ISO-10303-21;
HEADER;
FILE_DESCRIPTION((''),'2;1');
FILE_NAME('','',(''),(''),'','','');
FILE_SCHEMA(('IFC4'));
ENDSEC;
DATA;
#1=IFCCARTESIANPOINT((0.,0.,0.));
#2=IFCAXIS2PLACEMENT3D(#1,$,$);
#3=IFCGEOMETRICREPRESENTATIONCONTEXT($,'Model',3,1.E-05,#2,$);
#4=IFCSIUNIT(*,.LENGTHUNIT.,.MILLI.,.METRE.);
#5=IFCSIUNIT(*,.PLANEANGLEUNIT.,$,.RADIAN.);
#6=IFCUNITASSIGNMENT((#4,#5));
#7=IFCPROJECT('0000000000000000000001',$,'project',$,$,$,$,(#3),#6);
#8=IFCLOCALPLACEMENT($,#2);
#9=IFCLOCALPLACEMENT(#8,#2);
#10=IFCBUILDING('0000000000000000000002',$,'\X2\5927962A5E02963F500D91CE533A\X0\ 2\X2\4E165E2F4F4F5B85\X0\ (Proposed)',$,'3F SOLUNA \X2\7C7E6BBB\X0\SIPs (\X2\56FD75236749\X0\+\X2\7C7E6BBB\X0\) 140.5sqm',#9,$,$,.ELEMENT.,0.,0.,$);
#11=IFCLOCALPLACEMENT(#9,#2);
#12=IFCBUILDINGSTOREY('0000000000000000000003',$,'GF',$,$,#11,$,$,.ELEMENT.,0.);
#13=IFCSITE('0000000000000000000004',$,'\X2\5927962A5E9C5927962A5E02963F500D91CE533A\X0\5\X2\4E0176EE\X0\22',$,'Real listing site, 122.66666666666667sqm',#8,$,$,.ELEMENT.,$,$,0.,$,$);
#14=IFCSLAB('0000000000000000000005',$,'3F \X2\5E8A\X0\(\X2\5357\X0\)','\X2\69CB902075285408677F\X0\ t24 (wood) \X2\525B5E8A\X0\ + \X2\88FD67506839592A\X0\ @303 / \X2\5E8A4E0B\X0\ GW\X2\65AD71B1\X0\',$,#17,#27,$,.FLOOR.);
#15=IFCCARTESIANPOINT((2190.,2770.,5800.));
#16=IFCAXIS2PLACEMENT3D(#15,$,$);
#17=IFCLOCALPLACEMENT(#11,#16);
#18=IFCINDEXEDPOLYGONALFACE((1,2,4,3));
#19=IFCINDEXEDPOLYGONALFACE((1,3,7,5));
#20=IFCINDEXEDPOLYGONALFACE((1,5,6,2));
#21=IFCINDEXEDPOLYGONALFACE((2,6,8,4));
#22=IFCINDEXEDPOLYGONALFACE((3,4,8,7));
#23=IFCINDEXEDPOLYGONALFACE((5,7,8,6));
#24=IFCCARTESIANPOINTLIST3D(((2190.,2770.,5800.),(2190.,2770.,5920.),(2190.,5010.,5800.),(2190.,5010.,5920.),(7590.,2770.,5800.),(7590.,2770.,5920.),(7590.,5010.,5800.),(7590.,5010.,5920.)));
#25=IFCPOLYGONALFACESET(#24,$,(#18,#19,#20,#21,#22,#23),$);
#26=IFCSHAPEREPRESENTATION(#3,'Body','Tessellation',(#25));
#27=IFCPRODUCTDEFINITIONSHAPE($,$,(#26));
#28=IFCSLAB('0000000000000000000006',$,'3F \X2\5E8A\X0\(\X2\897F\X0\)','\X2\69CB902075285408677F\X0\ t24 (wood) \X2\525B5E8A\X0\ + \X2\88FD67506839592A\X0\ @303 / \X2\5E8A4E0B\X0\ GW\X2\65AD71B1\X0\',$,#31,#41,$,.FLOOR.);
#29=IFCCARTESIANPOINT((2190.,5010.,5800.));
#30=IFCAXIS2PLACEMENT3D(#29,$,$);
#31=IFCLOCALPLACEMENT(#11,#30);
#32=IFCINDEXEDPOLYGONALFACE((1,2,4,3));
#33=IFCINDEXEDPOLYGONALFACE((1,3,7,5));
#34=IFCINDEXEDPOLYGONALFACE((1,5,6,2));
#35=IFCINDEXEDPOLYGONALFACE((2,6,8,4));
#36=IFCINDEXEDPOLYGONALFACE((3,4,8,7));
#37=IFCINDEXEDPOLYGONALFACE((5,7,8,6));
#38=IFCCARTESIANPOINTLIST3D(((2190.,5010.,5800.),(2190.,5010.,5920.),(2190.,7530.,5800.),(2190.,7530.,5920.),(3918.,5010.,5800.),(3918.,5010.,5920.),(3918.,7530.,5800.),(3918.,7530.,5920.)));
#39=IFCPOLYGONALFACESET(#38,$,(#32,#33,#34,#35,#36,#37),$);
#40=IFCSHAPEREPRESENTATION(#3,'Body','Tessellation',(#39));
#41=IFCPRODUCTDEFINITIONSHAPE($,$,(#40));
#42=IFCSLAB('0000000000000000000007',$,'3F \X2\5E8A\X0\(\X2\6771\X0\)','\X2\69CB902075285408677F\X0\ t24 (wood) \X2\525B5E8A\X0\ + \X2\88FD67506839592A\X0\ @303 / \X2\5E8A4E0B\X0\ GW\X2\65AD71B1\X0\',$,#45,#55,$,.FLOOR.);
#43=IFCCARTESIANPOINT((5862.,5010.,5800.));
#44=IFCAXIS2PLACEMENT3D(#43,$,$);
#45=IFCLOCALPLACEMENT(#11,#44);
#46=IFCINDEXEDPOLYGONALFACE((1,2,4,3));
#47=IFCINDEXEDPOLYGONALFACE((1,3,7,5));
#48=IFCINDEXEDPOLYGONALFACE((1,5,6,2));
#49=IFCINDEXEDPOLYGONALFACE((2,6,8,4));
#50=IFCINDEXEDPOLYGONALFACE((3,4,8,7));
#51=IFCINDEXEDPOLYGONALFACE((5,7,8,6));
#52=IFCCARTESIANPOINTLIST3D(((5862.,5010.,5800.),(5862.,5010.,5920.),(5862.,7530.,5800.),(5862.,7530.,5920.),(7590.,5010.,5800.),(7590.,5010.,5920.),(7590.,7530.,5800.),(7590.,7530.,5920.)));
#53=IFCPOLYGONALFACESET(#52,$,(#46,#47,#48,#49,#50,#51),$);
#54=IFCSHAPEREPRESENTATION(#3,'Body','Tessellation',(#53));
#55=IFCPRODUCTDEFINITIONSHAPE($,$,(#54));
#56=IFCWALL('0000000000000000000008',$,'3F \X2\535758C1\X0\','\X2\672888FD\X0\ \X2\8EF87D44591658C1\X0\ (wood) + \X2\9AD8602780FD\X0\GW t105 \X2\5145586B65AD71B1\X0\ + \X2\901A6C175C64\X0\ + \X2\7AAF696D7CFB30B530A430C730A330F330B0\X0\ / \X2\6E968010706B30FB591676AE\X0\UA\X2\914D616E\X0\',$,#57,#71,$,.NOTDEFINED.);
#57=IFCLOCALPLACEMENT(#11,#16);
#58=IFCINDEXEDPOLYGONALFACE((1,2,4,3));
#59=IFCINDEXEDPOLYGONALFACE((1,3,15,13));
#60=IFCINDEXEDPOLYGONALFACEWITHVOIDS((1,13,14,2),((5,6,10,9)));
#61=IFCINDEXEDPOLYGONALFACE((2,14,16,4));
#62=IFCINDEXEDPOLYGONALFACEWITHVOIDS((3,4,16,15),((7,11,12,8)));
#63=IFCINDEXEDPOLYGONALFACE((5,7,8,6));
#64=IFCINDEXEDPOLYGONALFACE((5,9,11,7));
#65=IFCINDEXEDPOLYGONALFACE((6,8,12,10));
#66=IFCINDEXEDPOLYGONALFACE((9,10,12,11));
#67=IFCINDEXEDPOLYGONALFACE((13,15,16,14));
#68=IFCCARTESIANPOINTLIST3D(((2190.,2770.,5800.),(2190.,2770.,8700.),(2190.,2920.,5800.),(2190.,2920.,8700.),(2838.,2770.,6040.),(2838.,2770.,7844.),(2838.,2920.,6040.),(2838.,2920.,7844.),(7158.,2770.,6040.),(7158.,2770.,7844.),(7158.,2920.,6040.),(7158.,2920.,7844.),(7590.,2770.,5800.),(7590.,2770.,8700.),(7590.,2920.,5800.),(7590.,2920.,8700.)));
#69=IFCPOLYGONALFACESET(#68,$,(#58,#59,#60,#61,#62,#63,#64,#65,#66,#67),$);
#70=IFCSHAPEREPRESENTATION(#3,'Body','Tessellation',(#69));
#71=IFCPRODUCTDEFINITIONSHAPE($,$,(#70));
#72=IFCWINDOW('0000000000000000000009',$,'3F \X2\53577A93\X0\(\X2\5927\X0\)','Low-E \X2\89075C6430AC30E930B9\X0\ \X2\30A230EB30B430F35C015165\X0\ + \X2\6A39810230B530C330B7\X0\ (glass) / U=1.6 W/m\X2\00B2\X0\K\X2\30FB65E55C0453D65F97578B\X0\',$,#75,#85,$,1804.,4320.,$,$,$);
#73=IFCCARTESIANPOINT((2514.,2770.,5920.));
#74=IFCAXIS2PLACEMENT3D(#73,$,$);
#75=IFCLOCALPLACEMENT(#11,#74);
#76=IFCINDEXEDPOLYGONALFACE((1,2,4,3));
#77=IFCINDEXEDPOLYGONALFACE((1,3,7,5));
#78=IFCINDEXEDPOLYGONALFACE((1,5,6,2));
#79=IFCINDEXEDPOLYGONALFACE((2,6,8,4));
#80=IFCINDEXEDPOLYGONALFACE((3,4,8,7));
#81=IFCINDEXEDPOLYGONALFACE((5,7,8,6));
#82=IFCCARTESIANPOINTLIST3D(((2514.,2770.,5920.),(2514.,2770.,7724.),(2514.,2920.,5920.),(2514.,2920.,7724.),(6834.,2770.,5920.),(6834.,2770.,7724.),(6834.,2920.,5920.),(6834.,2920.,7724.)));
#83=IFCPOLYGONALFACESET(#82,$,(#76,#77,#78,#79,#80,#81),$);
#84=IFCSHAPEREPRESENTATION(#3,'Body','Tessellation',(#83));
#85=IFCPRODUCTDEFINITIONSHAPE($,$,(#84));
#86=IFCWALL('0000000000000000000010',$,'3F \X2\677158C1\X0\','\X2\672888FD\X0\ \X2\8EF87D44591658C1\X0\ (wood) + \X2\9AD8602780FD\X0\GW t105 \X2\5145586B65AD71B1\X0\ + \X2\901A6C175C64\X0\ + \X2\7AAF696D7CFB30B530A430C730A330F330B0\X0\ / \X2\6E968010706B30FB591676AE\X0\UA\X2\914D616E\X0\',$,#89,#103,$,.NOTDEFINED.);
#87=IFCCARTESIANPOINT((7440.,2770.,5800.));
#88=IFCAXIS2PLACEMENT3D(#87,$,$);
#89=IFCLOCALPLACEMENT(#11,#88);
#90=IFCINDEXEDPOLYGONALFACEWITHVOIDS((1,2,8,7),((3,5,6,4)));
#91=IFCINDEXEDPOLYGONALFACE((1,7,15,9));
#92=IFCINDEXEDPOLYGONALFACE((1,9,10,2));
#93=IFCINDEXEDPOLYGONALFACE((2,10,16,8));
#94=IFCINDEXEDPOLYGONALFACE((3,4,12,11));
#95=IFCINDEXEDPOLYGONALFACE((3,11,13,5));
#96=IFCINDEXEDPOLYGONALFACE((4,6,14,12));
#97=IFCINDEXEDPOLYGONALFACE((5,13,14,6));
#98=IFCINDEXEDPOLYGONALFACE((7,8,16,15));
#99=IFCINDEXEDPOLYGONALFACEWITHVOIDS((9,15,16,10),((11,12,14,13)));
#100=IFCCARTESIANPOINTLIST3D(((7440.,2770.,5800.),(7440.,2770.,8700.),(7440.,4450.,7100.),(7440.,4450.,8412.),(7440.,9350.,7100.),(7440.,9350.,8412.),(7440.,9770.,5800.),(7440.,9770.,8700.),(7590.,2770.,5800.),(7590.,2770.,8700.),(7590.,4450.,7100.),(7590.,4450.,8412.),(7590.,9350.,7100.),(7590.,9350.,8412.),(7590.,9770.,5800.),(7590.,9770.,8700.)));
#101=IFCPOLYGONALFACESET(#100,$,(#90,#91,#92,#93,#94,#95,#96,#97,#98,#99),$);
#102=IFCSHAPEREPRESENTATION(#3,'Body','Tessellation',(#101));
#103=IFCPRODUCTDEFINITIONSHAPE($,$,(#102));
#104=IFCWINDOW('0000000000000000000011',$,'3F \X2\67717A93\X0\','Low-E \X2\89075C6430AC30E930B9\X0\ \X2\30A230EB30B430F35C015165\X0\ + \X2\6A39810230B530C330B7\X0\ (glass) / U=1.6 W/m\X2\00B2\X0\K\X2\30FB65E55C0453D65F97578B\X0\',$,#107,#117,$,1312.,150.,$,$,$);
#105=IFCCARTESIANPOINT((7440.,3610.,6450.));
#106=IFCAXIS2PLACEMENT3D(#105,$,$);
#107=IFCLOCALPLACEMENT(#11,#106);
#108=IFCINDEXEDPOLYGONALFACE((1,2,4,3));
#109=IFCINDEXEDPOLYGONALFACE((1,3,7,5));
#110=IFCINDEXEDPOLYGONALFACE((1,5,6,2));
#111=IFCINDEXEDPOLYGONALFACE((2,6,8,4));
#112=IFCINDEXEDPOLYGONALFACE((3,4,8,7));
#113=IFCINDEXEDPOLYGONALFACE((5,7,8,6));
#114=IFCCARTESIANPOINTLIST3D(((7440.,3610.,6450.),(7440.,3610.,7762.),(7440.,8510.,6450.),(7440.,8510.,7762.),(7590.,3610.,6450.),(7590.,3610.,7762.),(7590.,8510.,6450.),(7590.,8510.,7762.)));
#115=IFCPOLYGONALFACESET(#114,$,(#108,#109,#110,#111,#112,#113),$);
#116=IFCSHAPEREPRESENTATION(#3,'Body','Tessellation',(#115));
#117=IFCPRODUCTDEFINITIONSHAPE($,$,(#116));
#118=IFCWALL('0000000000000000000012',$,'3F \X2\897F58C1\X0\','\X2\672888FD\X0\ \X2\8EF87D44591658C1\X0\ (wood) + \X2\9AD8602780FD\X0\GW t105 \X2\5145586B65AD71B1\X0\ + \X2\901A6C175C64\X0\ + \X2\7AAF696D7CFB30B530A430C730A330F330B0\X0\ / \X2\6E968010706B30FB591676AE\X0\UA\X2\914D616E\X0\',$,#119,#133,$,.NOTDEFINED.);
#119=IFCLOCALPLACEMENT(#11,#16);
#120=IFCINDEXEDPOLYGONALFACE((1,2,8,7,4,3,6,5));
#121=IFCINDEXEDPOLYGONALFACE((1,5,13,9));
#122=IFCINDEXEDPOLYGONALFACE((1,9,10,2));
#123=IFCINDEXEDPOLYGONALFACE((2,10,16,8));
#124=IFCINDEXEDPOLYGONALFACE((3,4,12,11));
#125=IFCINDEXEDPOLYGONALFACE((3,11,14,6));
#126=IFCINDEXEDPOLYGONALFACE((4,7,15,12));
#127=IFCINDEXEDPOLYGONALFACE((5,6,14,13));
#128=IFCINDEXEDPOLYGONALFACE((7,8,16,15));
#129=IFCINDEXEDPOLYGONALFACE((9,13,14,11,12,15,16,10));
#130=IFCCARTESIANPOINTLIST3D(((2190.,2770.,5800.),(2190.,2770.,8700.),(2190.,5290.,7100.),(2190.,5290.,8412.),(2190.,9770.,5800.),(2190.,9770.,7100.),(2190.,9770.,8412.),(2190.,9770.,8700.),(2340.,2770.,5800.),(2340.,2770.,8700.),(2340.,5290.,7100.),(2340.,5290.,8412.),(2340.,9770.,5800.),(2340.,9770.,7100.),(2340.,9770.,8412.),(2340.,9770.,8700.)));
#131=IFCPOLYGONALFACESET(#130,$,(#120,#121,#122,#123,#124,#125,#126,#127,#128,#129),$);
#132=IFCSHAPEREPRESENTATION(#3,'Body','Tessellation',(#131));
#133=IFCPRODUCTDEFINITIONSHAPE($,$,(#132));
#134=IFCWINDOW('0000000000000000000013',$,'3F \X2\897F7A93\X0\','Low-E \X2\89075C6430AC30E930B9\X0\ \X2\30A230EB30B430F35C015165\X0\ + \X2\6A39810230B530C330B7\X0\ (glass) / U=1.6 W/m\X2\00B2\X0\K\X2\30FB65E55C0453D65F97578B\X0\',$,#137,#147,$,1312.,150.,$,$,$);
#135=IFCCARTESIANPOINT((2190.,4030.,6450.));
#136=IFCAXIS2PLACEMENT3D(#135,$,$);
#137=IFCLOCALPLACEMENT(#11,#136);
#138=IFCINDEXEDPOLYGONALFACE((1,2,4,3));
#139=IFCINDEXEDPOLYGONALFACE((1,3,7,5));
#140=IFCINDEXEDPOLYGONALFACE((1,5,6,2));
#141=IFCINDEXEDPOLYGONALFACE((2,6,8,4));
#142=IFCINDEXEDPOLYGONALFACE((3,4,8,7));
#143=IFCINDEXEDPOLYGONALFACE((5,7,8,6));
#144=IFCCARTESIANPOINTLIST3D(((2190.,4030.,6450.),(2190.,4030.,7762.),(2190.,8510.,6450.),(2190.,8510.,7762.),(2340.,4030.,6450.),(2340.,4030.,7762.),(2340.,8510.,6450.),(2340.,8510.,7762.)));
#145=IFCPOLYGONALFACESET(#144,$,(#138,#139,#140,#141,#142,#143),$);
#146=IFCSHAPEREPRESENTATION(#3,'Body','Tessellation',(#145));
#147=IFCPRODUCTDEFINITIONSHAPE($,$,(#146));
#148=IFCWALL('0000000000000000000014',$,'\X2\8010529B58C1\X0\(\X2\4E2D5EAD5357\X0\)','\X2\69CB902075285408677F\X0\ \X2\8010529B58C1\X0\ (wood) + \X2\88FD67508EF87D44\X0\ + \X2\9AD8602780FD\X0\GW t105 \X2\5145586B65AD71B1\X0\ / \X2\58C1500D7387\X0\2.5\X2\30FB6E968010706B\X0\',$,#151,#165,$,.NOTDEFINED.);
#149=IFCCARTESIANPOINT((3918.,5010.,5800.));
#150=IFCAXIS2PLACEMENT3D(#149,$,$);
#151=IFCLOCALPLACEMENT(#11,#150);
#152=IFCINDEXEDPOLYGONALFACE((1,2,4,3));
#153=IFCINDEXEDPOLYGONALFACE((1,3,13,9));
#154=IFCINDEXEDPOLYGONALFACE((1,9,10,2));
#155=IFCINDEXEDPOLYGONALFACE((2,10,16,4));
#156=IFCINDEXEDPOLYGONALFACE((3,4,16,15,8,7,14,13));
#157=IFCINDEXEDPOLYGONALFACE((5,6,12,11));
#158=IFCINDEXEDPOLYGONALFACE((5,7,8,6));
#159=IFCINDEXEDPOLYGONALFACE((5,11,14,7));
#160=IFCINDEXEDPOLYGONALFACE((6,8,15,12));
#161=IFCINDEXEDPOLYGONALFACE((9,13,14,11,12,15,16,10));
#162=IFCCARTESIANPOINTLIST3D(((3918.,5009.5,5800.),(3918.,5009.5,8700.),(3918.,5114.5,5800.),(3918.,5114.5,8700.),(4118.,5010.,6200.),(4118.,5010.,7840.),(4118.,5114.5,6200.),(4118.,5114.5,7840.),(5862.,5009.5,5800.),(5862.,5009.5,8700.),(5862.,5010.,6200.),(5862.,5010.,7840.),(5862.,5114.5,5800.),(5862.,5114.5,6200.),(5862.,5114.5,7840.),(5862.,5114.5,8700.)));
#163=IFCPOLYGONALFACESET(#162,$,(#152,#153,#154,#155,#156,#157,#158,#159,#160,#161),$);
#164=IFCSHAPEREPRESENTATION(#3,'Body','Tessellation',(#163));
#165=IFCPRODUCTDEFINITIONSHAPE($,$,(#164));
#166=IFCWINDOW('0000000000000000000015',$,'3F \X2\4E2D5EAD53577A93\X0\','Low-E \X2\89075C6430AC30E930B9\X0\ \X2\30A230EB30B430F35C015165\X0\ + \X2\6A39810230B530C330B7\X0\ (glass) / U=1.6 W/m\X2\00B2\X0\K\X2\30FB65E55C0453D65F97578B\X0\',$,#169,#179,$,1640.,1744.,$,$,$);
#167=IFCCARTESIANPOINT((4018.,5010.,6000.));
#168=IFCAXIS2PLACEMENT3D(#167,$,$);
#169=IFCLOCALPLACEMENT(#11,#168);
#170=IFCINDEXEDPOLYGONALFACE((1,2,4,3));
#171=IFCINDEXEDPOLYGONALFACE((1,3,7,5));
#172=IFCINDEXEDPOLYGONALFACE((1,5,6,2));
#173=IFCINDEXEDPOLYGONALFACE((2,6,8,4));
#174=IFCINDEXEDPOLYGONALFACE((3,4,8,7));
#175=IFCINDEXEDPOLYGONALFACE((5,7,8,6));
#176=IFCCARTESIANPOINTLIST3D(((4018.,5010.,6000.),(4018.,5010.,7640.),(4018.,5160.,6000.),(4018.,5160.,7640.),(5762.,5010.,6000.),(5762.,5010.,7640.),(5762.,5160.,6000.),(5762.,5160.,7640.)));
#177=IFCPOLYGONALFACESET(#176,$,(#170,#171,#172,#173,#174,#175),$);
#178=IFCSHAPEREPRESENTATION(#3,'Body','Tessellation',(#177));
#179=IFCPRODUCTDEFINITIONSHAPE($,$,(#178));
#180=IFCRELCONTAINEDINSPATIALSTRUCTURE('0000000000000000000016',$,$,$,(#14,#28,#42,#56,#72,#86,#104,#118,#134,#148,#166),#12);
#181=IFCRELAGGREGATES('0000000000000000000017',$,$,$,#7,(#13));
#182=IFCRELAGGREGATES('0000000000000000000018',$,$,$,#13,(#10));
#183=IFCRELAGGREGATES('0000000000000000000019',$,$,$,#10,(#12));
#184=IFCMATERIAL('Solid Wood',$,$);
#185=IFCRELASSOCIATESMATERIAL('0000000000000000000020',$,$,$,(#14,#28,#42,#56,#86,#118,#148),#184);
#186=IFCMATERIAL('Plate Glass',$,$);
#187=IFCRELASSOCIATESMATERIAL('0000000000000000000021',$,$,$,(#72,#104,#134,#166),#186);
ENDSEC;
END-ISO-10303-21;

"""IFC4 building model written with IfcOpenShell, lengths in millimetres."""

from ifc_helpers import new_model, si_unit, frame, frame_2d, origin, place, context, project, spatial, rectangle, extrude, material, element, fill, save


model = new_model("IFC4")

# Units and contexts
model_context = context("Model", 3, precision=1e-05, world=origin())
ifc_project = project(units=[si_unit("LENGTHUNIT", "METRE", prefix="MILLI"), si_unit("PLANEANGLEUNIT", "RADIAN")], contexts=[model_context])

# Site, building, storey
site_placement = place(None, origin())
site = spatial("IfcSite", under=ifc_project, at=site_placement, Name="大阪府大阪市阿倍野区5丁目22", ObjectType="Real listing site, 122.66666666666667sqm", CompositionType="ELEMENT", RefElevation=0.0)
building_placement = place(site_placement, origin())
building = spatial("IfcBuilding", under=site, at=building_placement, Name="大阪市阿倍野区 2世帯住宅 (Proposed)", ObjectType="3F SOLUNA 籾殻SIPs (国産杉+籾殻) 140.5sqm", CompositionType="ELEMENT", ElevationOfRefHeight=0.0, ElevationOfTerrain=0.0)
storey_placement = place(building_placement, origin())
storey = spatial("IfcBuildingStorey", under=building, at=storey_placement, Name="GF", CompositionType="ELEMENT", Elevation=0.0)

# Slabs
ifc_material_1 = material(Name="Solid Wood")
slab_1_placement = place(storey_placement, frame((2190.0, 2770.0, 5800.0)))
element("IfcSlab", 1, at=slab_1_placement, inside=storey, material=ifc_material_1, Name="3F 床(南)", Description="構造用合板 t24 (wood) 剛床 + 製材根太 @303 / 床下 GW断熱", PredefinedType="FLOOR", context=model_context, shape_type="SweptSolid", body=[
    extrude(rectangle(XDim=5400.0, YDim=2240.0, at=frame_2d((2700.0, 1120.0))), frame((2190.0, 2770.0, 5800.0)), (0.0, 0.0, 1.0), 120.0),
])
slab_2_placement = place(storey_placement, frame((2190.0, 5010.0, 5800.0)))
element("IfcSlab", 2, at=slab_2_placement, inside=storey, material=ifc_material_1, Name="3F 床(西)", Description="構造用合板 t24 (wood) 剛床 + 製材根太 @303 / 床下 GW断熱", PredefinedType="FLOOR", context=model_context, shape_type="SweptSolid", body=[
    extrude(rectangle(XDim=1728.0, YDim=2520.0, at=frame_2d((864.0, 1260.0))), frame((2190.0, 5010.0, 5800.0)), (0.0, 0.0, 1.0), 120.0),
])
slab_3_placement = place(storey_placement, frame((5862.0, 5010.0, 5800.0)))
element("IfcSlab", 3, at=slab_3_placement, inside=storey, material=ifc_material_1, Name="3F 床(東)", Description="構造用合板 t24 (wood) 剛床 + 製材根太 @303 / 床下 GW断熱", PredefinedType="FLOOR", context=model_context, shape_type="SweptSolid", body=[
    extrude(rectangle(XDim=1728.0, YDim=2520.0, at=frame_2d((864.0, 1260.0))), frame((5862.0, 5010.0, 5800.0)), (0.0, 0.0, 1.0), 120.0),
])

# Walls, openings, windows
wall_1_placement = place(storey_placement, frame((2190.0, 2770.0, 5800.0)))
wall_1 = element("IfcWall", 4, at=wall_1_placement, inside=storey, material=ifc_material_1, Name="3F 南壁", Description="木製 軸組外壁 (wood) + 高性能GW t105 充填断熱 + 通気層 + 窯業系サイディング / 準耐火・外皮UA配慮", PredefinedType="NOTDEFINED", context=model_context, shape_type="SweptSolid", body=[
    extrude(rectangle(XDim=5400.0, YDim=150.0, at=frame_2d((2700.0, 75.0))), frame((2190.0, 2770.0, 5800.0)), (0.0, 0.0, 1.0), 2900.0),
])
opening_1_placement = place(storey_placement, frame((2514.0, 2770.0, 5920.0)))
opening_1 = element("IfcOpeningElement", 5, at=opening_1_placement, cuts=wall_1, PredefinedType="NOTDEFINED", context=model_context, shape_type="SweptSolid", body=[
    extrude(rectangle(XDim=4320.0, YDim=150.0, at=frame_2d((2160.0, 75.0))), frame((2514.0, 2770.0, 5920.0)), (0.0, 0.0, 1.0), 1804.0),
])
ifc_material_2 = material(Name="Plate Glass")
window_1_placement = place(storey_placement, frame((2514.0, 2770.0, 5920.0)))
window_1 = element("IfcWindow", 6, at=window_1_placement, inside=storey, material=ifc_material_2, Name="3F 南窓(大)", Description="Low-E 複層ガラス アルゴン封入 + 樹脂サッシ (glass) / U=1.6 W/m²K・日射取得型", OverallHeight=1804.0, OverallWidth=4320.0, context=model_context, shape_type="SweptSolid", body=[
    extrude(rectangle(XDim=4320.0, YDim=150.0, at=frame_2d((2160.0, 75.0))), frame((2514.0, 2770.0, 5920.0)), (0.0, 0.0, 1.0), 1804.0),
])
fill(opening_1, window_1)
wall_2_placement = place(storey_placement, frame((7440.0, 2770.0, 5800.0)))
wall_2 = element("IfcWall", 7, at=wall_2_placement, inside=storey, material=ifc_material_1, Name="3F 東壁", Description="木製 軸組外壁 (wood) + 高性能GW t105 充填断熱 + 通気層 + 窯業系サイディング / 準耐火・外皮UA配慮", PredefinedType="NOTDEFINED", context=model_context, shape_type="SweptSolid", body=[
    extrude(rectangle(XDim=150.0, YDim=7000.0, at=frame_2d((75.0, 3500.0))), frame((7440.0, 2770.0, 5800.0)), (0.0, 0.0, 1.0), 2900.0),
])
opening_2_placement = place(storey_placement, frame((7440.0, 3610.0, 6450.0)))
opening_2 = element("IfcOpeningElement", 8, at=opening_2_placement, cuts=wall_2, PredefinedType="NOTDEFINED", context=model_context, shape_type="SweptSolid", body=[
    extrude(rectangle(XDim=150.0, YDim=4900.0, at=frame_2d((75.0, 2450.0))), frame((7440.0, 3610.0, 6450.0)), (0.0, 0.0, 1.0), 1312.0),
])
window_2_placement = place(storey_placement, frame((7440.0, 3610.0, 6450.0)))
window_2 = element("IfcWindow", 9, at=window_2_placement, inside=storey, material=ifc_material_2, Name="3F 東窓", Description="Low-E 複層ガラス アルゴン封入 + 樹脂サッシ (glass) / U=1.6 W/m²K・日射取得型", OverallHeight=1312.0, OverallWidth=150.0, context=model_context, shape_type="SweptSolid", body=[
    extrude(rectangle(XDim=150.0, YDim=4900.0, at=frame_2d((75.0, 2450.0))), frame((7440.0, 3610.0, 6450.0)), (0.0, 0.0, 1.0), 1312.0),
])
fill(opening_2, window_2)
wall_3_placement = place(storey_placement, frame((2190.0, 2770.0, 5800.0)))
wall_3 = element("IfcWall", 10, at=wall_3_placement, inside=storey, material=ifc_material_1, Name="3F 西壁", Description="木製 軸組外壁 (wood) + 高性能GW t105 充填断熱 + 通気層 + 窯業系サイディング / 準耐火・外皮UA配慮", PredefinedType="NOTDEFINED", context=model_context, shape_type="SweptSolid", body=[
    extrude(rectangle(XDim=150.0, YDim=7000.0, at=frame_2d((75.0, 3500.0))), frame((2190.0, 2770.0, 5800.0)), (0.0, 0.0, 1.0), 2900.0),
])
opening_3_placement = place(storey_placement, frame((2190.0, 4030.0, 6450.0)))
opening_3 = element("IfcOpeningElement", 11, at=opening_3_placement, cuts=wall_3, PredefinedType="NOTDEFINED", context=model_context, shape_type="SweptSolid", body=[
    extrude(rectangle(XDim=150.0, YDim=4480.0, at=frame_2d((75.0, 2240.0))), frame((2190.0, 4030.0, 6450.0)), (0.0, 0.0, 1.0), 1312.0),
])
window_3_placement = place(storey_placement, frame((2190.0, 4030.0, 6450.0)))
window_3 = element("IfcWindow", 12, at=window_3_placement, inside=storey, material=ifc_material_2, Name="3F 西窓", Description="Low-E 複層ガラス アルゴン封入 + 樹脂サッシ (glass) / U=1.6 W/m²K・日射取得型", OverallHeight=1312.0, OverallWidth=150.0, context=model_context, shape_type="SweptSolid", body=[
    extrude(rectangle(XDim=150.0, YDim=4480.0, at=frame_2d((75.0, 2240.0))), frame((2190.0, 4030.0, 6450.0)), (0.0, 0.0, 1.0), 1312.0),
])
fill(opening_3, window_3)
wall_4_placement = place(storey_placement, frame((3918.0, 5010.0, 5800.0)))
wall_4 = element("IfcWall", 13, at=wall_4_placement, inside=storey, material=ifc_material_1, Name="耐力壁(中庭南)", Description="構造用合板 耐力壁 (wood) + 製材軸組 + 高性能GW t105 充填断熱 / 壁倍率2.5・準耐火", PredefinedType="NOTDEFINED", context=model_context, shape_type="SweptSolid", body=[
    extrude(rectangle(XDim=1944.0, YDim=105.0, at=frame_2d((972.0, 52.0))), frame((3918.0, 5010.0, 5800.0)), (0.0, 0.0, 1.0), 2900.0),
])
opening_4_placement = place(storey_placement, frame((4018.0, 5010.0, 6000.0)))
opening_4 = element("IfcOpeningElement", 14, at=opening_4_placement, cuts=wall_4, PredefinedType="NOTDEFINED", context=model_context, shape_type="SweptSolid", body=[
    extrude(rectangle(XDim=1744.0, YDim=150.0, at=frame_2d((872.0, 75.0))), frame((4018.0, 5010.0, 6000.0)), (0.0, 0.0, 1.0), 1640.0),
])
window_4_placement = place(storey_placement, frame((4018.0, 5010.0, 6000.0)))
window_4 = element("IfcWindow", 15, at=window_4_placement, inside=storey, material=ifc_material_2, Name="3F 中庭南窓", Description="Low-E 複層ガラス アルゴン封入 + 樹脂サッシ (glass) / U=1.6 W/m²K・日射取得型", OverallHeight=1640.0, OverallWidth=1744.0, context=model_context, shape_type="SweptSolid", body=[
    extrude(rectangle(XDim=1744.0, YDim=150.0, at=frame_2d((872.0, 75.0))), frame((4018.0, 5010.0, 6000.0)), (0.0, 0.0, 1.0), 1640.0),
])
fill(opening_4, window_4)

save(model, "model.ifc")
